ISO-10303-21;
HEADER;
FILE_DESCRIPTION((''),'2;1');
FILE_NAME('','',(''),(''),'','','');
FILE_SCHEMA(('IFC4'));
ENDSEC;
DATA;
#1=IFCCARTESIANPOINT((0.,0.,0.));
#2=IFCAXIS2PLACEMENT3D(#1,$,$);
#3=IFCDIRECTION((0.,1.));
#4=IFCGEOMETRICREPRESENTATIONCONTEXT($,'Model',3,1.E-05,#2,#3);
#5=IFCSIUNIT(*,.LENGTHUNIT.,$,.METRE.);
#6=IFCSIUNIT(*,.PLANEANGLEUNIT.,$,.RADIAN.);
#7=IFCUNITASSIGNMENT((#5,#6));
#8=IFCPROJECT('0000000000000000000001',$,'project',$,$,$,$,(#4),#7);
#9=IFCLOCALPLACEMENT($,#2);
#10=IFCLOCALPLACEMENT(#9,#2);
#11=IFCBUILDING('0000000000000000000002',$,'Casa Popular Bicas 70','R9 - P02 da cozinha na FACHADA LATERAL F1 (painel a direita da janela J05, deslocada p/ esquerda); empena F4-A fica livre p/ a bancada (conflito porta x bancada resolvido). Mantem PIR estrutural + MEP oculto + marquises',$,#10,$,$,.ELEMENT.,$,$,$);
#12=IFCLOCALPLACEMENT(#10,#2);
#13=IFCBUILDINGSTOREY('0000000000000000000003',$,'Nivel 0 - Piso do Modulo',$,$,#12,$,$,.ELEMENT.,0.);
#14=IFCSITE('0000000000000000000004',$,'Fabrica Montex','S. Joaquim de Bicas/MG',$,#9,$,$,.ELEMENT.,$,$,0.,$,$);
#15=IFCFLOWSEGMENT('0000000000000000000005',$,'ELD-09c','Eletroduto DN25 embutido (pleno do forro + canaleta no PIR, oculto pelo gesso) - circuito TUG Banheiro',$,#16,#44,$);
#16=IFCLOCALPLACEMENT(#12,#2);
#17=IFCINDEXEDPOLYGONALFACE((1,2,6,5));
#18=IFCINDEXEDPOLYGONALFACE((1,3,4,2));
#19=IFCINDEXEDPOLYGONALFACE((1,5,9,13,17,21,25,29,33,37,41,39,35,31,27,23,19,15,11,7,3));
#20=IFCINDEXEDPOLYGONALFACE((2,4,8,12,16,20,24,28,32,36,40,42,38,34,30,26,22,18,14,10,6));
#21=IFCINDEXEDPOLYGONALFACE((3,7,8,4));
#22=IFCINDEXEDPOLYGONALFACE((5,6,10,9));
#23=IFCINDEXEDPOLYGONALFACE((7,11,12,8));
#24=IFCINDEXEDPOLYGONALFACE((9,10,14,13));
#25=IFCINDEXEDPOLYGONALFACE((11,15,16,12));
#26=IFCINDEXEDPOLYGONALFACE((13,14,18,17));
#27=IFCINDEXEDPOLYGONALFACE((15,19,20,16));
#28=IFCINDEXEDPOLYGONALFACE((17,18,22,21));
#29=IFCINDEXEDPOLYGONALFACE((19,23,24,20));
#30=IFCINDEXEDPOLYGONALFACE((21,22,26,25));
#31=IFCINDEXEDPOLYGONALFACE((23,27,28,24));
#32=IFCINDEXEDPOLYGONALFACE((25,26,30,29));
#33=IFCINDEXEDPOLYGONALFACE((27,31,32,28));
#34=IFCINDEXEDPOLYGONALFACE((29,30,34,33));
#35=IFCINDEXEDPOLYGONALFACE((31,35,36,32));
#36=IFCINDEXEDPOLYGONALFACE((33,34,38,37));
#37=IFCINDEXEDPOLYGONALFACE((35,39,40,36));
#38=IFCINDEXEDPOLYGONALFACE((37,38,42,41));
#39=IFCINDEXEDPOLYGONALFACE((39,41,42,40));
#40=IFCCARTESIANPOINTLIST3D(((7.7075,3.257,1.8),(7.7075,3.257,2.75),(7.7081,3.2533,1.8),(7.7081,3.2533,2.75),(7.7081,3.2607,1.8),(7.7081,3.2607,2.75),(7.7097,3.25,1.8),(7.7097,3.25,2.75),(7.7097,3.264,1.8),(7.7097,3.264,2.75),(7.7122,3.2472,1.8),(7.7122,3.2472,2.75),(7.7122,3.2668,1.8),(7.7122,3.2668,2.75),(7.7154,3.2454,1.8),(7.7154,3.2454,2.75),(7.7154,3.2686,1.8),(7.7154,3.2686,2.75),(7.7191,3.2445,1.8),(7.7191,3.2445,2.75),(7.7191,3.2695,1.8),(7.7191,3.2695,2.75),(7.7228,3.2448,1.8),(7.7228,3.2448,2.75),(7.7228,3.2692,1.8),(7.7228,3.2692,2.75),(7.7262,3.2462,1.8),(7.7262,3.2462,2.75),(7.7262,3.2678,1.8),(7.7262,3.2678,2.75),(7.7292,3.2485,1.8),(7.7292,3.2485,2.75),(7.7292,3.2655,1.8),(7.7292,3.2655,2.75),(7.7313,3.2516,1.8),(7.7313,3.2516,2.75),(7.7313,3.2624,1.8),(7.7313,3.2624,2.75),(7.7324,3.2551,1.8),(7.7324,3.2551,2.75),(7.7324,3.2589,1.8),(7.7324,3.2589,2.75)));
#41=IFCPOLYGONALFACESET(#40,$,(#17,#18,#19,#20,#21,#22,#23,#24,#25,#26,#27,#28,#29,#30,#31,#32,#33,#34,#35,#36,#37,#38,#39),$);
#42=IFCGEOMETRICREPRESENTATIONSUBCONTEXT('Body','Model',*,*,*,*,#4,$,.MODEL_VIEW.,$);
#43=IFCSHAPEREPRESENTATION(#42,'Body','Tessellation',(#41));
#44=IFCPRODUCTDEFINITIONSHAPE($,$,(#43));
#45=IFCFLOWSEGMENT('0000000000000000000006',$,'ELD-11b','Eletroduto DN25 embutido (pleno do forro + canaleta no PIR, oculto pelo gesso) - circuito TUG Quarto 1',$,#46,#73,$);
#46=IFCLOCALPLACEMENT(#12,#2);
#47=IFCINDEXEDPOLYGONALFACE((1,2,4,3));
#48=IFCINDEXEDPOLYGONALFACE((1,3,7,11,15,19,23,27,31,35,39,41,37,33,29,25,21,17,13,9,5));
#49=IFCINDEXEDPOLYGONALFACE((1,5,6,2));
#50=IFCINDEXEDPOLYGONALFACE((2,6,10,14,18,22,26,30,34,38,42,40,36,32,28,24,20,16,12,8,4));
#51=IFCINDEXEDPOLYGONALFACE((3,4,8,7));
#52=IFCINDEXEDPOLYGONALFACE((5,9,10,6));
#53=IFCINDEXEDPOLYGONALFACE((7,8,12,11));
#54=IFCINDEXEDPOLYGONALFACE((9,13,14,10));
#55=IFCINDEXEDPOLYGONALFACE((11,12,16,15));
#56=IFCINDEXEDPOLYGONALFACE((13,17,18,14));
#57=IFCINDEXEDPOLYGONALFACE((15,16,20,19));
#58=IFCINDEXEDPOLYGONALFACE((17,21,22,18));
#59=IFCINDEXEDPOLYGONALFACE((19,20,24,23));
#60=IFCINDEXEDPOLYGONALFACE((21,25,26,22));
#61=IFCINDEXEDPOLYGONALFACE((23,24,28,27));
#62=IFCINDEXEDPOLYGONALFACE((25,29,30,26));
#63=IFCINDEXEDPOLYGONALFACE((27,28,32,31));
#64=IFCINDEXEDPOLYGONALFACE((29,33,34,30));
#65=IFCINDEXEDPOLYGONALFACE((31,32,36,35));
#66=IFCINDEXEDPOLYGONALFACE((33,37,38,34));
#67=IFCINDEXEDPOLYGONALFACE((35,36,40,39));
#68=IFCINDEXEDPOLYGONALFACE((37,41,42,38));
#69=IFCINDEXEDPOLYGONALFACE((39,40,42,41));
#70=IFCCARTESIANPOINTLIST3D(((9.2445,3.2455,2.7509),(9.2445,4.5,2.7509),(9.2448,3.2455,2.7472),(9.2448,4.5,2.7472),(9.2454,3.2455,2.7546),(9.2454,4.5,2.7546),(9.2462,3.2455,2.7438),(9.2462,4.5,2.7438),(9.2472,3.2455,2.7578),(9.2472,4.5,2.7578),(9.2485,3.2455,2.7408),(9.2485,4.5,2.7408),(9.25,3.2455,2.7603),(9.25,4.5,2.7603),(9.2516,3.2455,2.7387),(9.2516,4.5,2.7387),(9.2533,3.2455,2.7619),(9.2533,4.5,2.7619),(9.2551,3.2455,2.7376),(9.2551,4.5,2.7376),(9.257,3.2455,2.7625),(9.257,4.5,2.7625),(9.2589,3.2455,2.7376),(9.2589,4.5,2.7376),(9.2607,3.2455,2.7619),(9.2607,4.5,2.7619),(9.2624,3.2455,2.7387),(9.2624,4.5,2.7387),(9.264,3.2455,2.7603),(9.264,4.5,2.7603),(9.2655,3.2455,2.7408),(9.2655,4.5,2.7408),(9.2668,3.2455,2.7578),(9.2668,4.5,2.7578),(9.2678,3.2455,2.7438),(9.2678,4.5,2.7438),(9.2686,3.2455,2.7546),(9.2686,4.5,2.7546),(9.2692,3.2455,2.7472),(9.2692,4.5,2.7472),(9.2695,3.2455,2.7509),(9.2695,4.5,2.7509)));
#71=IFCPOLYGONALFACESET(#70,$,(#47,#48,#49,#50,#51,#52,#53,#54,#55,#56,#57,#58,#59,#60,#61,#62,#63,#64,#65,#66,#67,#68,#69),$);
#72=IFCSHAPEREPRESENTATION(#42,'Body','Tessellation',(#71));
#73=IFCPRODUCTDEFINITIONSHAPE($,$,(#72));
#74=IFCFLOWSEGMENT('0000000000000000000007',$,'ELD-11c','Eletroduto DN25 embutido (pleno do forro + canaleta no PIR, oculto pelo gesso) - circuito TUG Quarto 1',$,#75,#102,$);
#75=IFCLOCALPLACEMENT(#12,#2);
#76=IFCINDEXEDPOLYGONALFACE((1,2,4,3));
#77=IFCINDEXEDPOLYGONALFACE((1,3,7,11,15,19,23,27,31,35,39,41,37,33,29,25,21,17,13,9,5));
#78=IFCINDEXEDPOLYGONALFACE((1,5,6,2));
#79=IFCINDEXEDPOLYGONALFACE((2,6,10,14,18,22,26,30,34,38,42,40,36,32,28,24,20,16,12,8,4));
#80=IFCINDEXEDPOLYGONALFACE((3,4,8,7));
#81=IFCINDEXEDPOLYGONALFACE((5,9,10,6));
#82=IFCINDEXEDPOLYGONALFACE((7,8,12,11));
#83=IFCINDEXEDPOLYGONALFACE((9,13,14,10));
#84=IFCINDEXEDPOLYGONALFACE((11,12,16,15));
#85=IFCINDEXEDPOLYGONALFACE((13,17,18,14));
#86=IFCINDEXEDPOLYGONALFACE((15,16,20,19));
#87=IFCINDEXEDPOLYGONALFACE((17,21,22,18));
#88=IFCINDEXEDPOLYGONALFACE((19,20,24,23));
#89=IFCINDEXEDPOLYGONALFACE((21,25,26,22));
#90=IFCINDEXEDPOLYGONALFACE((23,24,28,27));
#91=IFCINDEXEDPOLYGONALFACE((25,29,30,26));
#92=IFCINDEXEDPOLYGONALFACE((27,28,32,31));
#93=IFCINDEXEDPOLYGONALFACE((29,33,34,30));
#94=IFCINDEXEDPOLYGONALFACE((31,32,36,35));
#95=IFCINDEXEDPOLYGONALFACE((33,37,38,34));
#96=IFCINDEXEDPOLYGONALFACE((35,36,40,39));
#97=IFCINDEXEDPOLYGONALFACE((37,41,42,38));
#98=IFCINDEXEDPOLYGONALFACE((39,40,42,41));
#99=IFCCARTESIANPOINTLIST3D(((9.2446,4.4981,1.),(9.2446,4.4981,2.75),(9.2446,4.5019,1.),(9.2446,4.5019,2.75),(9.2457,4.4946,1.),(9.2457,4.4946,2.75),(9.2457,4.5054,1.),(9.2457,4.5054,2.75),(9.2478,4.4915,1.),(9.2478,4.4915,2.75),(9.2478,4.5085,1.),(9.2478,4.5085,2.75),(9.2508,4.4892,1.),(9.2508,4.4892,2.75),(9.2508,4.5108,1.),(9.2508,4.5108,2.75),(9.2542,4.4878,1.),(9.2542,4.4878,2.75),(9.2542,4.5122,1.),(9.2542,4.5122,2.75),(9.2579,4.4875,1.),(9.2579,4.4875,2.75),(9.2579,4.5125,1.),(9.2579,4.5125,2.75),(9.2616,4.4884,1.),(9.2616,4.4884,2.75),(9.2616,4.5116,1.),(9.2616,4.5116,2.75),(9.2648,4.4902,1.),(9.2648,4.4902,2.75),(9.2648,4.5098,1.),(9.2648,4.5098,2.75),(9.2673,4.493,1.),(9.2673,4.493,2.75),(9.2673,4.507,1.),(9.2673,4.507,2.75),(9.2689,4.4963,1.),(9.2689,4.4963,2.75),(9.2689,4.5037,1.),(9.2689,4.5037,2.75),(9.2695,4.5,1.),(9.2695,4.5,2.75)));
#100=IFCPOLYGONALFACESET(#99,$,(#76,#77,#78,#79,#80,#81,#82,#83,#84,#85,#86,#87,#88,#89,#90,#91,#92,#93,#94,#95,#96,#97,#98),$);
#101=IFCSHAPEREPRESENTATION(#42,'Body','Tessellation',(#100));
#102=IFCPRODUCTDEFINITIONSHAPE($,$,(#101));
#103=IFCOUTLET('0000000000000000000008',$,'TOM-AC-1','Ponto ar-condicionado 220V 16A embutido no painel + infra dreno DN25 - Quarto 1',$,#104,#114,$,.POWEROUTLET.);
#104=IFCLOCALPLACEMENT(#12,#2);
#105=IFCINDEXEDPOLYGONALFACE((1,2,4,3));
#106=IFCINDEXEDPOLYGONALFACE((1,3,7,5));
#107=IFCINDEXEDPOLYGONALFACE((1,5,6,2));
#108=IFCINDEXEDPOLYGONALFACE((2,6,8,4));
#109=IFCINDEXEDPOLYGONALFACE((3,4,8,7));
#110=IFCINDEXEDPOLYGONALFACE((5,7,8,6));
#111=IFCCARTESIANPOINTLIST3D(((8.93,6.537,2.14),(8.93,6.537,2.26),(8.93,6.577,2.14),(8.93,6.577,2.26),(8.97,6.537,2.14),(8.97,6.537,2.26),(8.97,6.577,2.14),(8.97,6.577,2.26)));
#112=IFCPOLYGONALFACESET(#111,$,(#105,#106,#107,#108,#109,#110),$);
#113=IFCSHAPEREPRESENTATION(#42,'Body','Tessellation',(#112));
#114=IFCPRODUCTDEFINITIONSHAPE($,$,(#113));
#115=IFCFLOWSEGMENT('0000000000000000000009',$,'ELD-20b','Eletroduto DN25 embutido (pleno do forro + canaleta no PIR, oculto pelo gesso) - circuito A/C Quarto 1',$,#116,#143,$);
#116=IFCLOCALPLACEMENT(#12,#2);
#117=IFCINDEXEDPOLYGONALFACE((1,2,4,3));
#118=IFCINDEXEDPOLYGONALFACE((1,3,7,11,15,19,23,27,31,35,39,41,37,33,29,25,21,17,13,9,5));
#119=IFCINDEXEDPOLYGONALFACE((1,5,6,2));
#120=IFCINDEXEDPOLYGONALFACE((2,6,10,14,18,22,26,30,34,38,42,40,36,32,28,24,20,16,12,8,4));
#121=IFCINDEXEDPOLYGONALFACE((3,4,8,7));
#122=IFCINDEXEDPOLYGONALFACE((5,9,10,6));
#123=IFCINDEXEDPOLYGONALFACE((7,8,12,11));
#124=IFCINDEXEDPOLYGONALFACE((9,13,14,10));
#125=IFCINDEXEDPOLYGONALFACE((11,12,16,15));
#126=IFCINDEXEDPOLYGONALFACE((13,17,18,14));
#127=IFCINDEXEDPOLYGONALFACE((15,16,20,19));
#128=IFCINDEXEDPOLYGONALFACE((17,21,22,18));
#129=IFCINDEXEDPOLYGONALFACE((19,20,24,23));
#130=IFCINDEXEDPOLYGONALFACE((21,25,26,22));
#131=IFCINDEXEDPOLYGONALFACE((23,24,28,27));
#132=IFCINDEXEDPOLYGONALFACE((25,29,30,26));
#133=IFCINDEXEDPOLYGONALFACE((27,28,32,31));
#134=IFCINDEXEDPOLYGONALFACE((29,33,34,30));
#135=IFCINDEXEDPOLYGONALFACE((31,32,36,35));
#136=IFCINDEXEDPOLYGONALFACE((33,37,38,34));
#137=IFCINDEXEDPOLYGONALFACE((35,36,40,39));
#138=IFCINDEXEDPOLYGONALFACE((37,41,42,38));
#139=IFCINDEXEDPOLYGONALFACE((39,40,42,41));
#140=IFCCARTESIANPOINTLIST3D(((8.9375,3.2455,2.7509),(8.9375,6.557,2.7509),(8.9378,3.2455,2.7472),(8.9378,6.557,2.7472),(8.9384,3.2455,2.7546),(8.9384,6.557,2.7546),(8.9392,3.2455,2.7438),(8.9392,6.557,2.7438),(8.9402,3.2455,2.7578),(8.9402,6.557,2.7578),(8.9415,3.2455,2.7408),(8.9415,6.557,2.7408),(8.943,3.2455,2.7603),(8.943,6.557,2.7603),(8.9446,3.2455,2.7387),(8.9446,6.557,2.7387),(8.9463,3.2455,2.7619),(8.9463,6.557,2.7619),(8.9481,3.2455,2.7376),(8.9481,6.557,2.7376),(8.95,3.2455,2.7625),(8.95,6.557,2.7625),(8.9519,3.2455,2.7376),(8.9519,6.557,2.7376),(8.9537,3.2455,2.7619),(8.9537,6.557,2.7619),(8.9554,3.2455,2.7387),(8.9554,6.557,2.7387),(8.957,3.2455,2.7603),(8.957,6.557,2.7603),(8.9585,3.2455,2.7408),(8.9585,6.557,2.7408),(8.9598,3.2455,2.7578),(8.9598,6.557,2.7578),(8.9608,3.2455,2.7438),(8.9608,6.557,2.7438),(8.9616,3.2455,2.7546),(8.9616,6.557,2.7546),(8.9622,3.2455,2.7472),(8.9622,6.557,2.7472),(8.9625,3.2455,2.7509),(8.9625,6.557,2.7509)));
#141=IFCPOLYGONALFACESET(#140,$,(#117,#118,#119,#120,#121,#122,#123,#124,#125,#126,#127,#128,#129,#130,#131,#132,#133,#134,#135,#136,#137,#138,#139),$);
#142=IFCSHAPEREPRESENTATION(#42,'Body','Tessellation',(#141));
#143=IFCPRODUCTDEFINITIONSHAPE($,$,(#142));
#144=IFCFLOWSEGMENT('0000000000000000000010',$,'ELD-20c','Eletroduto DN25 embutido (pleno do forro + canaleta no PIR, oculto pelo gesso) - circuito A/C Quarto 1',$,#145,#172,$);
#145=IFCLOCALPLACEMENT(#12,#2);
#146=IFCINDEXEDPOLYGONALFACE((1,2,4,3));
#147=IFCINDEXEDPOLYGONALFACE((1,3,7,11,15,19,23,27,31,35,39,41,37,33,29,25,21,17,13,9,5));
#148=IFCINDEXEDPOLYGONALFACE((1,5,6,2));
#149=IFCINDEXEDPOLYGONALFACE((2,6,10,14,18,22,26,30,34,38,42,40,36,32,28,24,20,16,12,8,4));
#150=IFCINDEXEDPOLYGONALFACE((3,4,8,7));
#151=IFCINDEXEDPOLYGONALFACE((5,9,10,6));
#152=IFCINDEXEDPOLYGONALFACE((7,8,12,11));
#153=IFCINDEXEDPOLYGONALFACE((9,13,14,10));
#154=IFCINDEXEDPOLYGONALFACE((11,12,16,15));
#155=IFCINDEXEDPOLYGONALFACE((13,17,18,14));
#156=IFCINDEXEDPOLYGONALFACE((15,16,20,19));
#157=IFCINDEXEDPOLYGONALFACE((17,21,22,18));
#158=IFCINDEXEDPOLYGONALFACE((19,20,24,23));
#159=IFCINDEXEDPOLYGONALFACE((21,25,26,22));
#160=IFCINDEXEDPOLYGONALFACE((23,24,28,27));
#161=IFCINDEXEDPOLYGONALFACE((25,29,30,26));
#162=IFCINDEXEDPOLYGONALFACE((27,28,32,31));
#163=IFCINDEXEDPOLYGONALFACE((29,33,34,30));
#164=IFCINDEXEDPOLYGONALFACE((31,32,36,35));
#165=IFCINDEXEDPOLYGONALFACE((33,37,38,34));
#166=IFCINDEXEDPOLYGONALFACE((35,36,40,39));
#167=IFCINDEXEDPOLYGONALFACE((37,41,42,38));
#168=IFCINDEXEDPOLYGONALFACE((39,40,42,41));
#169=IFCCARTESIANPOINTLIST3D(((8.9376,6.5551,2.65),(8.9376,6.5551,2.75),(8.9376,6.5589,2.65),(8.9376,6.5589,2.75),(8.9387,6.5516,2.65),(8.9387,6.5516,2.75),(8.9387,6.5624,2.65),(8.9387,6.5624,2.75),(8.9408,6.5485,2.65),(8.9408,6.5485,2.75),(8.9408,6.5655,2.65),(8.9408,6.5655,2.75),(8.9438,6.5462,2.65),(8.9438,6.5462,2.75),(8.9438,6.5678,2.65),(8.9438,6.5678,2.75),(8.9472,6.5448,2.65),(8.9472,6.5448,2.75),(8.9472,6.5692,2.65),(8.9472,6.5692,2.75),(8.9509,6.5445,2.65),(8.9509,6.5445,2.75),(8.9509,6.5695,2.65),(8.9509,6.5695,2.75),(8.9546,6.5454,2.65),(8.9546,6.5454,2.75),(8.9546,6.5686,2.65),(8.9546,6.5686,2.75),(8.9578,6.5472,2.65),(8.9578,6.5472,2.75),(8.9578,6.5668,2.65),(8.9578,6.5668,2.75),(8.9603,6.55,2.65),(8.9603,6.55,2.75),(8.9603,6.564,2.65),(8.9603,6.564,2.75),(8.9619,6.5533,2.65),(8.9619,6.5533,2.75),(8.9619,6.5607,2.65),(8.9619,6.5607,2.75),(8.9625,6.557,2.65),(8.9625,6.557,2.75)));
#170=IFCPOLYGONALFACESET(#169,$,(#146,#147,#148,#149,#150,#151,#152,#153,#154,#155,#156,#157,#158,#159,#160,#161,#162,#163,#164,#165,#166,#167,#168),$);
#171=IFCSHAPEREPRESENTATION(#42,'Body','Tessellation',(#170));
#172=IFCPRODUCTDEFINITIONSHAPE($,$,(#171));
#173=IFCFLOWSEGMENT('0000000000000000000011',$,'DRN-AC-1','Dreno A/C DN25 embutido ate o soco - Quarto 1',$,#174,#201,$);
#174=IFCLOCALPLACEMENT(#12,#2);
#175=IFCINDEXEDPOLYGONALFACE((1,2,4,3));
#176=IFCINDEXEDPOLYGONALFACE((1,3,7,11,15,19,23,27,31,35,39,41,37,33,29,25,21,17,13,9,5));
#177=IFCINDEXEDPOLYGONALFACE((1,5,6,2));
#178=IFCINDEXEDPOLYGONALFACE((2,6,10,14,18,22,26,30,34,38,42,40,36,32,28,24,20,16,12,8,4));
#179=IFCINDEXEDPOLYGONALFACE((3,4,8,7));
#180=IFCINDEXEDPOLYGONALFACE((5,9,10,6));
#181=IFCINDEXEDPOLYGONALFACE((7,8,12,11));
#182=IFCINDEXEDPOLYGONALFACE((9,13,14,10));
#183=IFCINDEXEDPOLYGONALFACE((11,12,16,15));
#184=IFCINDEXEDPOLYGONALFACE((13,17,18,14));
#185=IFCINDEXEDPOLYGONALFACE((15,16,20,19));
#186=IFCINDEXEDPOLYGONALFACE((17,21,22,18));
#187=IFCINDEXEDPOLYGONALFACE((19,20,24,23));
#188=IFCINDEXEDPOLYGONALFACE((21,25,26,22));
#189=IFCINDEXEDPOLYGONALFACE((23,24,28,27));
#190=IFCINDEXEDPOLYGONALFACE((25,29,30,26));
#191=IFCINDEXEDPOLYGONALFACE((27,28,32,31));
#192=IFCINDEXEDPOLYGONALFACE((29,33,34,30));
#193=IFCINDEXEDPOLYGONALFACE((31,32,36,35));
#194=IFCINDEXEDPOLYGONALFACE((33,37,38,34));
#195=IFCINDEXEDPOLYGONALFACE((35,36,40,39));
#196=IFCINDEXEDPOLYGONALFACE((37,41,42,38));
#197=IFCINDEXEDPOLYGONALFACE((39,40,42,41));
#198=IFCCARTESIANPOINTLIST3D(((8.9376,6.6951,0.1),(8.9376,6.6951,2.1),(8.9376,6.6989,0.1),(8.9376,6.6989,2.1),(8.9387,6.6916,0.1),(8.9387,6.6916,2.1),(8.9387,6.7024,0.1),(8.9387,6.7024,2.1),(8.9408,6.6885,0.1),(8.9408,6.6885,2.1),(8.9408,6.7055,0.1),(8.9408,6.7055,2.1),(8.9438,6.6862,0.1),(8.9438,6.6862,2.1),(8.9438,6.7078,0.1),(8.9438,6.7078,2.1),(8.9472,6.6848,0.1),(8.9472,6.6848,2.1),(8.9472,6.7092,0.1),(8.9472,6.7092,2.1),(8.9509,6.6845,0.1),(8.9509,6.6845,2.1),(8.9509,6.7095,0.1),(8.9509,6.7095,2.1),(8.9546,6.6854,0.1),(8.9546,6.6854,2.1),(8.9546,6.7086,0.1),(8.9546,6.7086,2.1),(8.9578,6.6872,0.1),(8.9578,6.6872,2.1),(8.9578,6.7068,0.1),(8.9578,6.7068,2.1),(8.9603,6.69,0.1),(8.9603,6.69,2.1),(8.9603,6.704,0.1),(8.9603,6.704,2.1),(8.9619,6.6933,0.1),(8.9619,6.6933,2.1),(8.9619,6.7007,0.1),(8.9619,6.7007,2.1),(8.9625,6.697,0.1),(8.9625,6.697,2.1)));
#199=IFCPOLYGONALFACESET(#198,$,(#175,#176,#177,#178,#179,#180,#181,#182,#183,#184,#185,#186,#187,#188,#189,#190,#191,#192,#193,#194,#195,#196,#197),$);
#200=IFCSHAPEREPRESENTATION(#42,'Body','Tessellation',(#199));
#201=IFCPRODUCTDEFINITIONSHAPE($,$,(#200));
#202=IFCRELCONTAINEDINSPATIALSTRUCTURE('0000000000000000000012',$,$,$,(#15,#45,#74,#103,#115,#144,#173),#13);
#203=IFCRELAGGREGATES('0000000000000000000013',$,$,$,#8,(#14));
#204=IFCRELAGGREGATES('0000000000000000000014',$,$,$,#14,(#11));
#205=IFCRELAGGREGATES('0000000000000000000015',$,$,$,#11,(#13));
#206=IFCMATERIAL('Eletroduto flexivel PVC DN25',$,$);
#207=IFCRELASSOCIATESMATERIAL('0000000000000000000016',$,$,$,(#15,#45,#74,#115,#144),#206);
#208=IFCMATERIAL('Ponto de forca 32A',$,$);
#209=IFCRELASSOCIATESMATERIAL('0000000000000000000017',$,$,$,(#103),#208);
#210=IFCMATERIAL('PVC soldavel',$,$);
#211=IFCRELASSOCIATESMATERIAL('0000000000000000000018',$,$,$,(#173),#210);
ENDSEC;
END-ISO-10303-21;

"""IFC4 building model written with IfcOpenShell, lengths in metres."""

from ifc_helpers import new_model, si_unit, direction, frame, frame_2d, origin, origin_2d, place, context, subcontext, project, spatial, rectangle, circle, extrude, material, element, save


model = new_model("IFC4")

# Units and contexts
model_context = context("Model", 3, precision=1e-05, world=origin(), true_north=direction((0.0, 1.0)))
body_context = subcontext(model_context, "Body", "Model", "MODEL_VIEW")
ifc_project = project(units=[si_unit("LENGTHUNIT", "METRE"), si_unit("PLANEANGLEUNIT", "RADIAN")], contexts=[model_context])

# Site, building, storey
site_placement = place(None, origin())
site = spatial("IfcSite", under=ifc_project, at=site_placement, Name="Fabrica Montex", Description="S. Joaquim de Bicas/MG", CompositionType="ELEMENT", RefElevation=0.0)
building_placement = place(site_placement, origin())
building = spatial("IfcBuilding", under=site, at=building_placement, Name="Casa Popular Bicas 70", Description="R9 - P02 da cozinha na FACHADA LATERAL F1 (painel a direita da janela J05, deslocada p/ esquerda); empena F4-A fica livre p/ a bancada (conflito porta x bancada resolvido). Mantem PIR estrutural + MEP oculto + marquises", CompositionType="ELEMENT")
storey_placement = place(building_placement, origin())
storey = spatial("IfcBuildingStorey", under=building, at=storey_placement, Name="Nivel 0 - Piso do Modulo", CompositionType="ELEMENT", Elevation=0.0)

# Shared definitions
ifc_material_1 = material(Name="Eletroduto flexivel PVC DN25")

# Flow segments
flow_segment_1_placement = place(None, frame((7.72, 3.257, 2.75), z_axis=(0.0, 0.0, -1.0), x_axis=(-1.0, 0.0, 0.0)))
element("IfcFlowSegment", 1, at=flow_segment_1_placement, inside=storey, material=ifc_material_1, Name="ELD-09c", Description="Eletroduto DN25 embutido (pleno do forro + canaleta no PIR, oculto pelo gesso) - circuito TUG Banheiro", context=body_context, shape_type="SweptSolid", body=[
    extrude(circle(Radius=0.0125, at=origin_2d()), origin(), (0.0, 0.0, 1.0), 0.95),
])
flow_segment_2_placement = place(storey_placement, frame((9.257, 3.2455, 2.75), z_axis=(0.0, 1.0, 0.0), x_axis=(0.0, 0.0, 1.0)))
element("IfcFlowSegment", 2, at=flow_segment_2_placement, inside=storey, material=ifc_material_1, Name="ELD-11b", Description="Eletroduto DN25 embutido (pleno do forro + canaleta no PIR, oculto pelo gesso) - circuito TUG Quarto 1", context=body_context, shape_type="SweptSolid", body=[
    extrude(circle(Radius=0.0125, at=origin_2d()), origin(), (0.0, 0.0, 1.0), 1.2545),
])
flow_segment_3_placement = place(storey_placement, frame((9.257, 4.5, 2.75), z_axis=(0.0, 0.0, -1.0), x_axis=(1.0, 0.0, 0.0)))
element("IfcFlowSegment", 3, at=flow_segment_3_placement, inside=storey, material=ifc_material_1, Name="ELD-11c", Description="Eletroduto DN25 embutido (pleno do forro + canaleta no PIR, oculto pelo gesso) - circuito TUG Quarto 1", context=body_context, shape_type="SweptSolid", body=[
    extrude(circle(Radius=0.0125, at=origin_2d()), origin(), (0.0, 0.0, 1.0), 1.75),
])

# Outlet
ifc_material_2 = material(Name="Ponto de forca 32A")
outlet_1_placement = place(storey_placement, frame((8.93, 6.537, 2.14)))
element("IfcOutlet", 4, at=outlet_1_placement, inside=storey, material=ifc_material_2, Name="TOM-AC-1", Description="Ponto ar-condicionado 220V 16A embutido no painel + infra dreno DN25 - Quarto 1", PredefinedType="POWEROUTLET", context=body_context, shape_type="SweptSolid", body=[
    extrude(rectangle(XDim=0.04, YDim=0.04, at=frame_2d((0.02, 0.02))), origin(), (0.0, 0.0, 1.0), 0.12),
])

# Flow segments
flow_segment_4_placement = place(storey_placement, frame((8.95, 3.2455, 2.75), z_axis=(0.0, 1.0, 0.0), x_axis=(0.0, 0.0, 1.0)))
element("IfcFlowSegment", 5, at=flow_segment_4_placement, inside=storey, material=ifc_material_1, Name="ELD-20b", Description="Eletroduto DN25 embutido (pleno do forro + canaleta no PIR, oculto pelo gesso) - circuito A/C Quarto 1", context=body_context, shape_type="SweptSolid", body=[
    extrude(circle(Radius=0.0125, at=origin_2d()), origin(), (0.0, 0.0, 1.0), 3.3115),
])
flow_segment_5_placement = place(storey_placement, frame((8.95, 6.557, 2.75), z_axis=(0.0, 0.0, -1.0), x_axis=(1.0, 0.0, 0.0)))
element("IfcFlowSegment", 6, at=flow_segment_5_placement, inside=storey, material=ifc_material_1, Name="ELD-20c", Description="Eletroduto DN25 embutido (pleno do forro + canaleta no PIR, oculto pelo gesso) - circuito A/C Quarto 1", context=body_context, shape_type="SweptSolid", body=[
    extrude(circle(Radius=0.0125, at=origin_2d()), origin(), (0.0, 0.0, 1.0), 0.1),
])
ifc_material_3 = material(Name="PVC soldavel")
flow_segment_6_placement = place(storey_placement, frame((8.95, 6.697, 2.1), z_axis=(0.0, 0.0, -1.0), x_axis=(1.0, 0.0, 0.0)))
element("IfcFlowSegment", 7, at=flow_segment_6_placement, inside=storey, material=ifc_material_3, Name="DRN-AC-1", Description="Dreno A/C DN25 embutido ate o soco - Quarto 1", context=body_context, shape_type="SweptSolid", body=[
    extrude(circle(Radius=0.0125, at=origin_2d()), origin(), (0.0, 0.0, 1.0), 2.0),
])

save(model, "model.ifc")
